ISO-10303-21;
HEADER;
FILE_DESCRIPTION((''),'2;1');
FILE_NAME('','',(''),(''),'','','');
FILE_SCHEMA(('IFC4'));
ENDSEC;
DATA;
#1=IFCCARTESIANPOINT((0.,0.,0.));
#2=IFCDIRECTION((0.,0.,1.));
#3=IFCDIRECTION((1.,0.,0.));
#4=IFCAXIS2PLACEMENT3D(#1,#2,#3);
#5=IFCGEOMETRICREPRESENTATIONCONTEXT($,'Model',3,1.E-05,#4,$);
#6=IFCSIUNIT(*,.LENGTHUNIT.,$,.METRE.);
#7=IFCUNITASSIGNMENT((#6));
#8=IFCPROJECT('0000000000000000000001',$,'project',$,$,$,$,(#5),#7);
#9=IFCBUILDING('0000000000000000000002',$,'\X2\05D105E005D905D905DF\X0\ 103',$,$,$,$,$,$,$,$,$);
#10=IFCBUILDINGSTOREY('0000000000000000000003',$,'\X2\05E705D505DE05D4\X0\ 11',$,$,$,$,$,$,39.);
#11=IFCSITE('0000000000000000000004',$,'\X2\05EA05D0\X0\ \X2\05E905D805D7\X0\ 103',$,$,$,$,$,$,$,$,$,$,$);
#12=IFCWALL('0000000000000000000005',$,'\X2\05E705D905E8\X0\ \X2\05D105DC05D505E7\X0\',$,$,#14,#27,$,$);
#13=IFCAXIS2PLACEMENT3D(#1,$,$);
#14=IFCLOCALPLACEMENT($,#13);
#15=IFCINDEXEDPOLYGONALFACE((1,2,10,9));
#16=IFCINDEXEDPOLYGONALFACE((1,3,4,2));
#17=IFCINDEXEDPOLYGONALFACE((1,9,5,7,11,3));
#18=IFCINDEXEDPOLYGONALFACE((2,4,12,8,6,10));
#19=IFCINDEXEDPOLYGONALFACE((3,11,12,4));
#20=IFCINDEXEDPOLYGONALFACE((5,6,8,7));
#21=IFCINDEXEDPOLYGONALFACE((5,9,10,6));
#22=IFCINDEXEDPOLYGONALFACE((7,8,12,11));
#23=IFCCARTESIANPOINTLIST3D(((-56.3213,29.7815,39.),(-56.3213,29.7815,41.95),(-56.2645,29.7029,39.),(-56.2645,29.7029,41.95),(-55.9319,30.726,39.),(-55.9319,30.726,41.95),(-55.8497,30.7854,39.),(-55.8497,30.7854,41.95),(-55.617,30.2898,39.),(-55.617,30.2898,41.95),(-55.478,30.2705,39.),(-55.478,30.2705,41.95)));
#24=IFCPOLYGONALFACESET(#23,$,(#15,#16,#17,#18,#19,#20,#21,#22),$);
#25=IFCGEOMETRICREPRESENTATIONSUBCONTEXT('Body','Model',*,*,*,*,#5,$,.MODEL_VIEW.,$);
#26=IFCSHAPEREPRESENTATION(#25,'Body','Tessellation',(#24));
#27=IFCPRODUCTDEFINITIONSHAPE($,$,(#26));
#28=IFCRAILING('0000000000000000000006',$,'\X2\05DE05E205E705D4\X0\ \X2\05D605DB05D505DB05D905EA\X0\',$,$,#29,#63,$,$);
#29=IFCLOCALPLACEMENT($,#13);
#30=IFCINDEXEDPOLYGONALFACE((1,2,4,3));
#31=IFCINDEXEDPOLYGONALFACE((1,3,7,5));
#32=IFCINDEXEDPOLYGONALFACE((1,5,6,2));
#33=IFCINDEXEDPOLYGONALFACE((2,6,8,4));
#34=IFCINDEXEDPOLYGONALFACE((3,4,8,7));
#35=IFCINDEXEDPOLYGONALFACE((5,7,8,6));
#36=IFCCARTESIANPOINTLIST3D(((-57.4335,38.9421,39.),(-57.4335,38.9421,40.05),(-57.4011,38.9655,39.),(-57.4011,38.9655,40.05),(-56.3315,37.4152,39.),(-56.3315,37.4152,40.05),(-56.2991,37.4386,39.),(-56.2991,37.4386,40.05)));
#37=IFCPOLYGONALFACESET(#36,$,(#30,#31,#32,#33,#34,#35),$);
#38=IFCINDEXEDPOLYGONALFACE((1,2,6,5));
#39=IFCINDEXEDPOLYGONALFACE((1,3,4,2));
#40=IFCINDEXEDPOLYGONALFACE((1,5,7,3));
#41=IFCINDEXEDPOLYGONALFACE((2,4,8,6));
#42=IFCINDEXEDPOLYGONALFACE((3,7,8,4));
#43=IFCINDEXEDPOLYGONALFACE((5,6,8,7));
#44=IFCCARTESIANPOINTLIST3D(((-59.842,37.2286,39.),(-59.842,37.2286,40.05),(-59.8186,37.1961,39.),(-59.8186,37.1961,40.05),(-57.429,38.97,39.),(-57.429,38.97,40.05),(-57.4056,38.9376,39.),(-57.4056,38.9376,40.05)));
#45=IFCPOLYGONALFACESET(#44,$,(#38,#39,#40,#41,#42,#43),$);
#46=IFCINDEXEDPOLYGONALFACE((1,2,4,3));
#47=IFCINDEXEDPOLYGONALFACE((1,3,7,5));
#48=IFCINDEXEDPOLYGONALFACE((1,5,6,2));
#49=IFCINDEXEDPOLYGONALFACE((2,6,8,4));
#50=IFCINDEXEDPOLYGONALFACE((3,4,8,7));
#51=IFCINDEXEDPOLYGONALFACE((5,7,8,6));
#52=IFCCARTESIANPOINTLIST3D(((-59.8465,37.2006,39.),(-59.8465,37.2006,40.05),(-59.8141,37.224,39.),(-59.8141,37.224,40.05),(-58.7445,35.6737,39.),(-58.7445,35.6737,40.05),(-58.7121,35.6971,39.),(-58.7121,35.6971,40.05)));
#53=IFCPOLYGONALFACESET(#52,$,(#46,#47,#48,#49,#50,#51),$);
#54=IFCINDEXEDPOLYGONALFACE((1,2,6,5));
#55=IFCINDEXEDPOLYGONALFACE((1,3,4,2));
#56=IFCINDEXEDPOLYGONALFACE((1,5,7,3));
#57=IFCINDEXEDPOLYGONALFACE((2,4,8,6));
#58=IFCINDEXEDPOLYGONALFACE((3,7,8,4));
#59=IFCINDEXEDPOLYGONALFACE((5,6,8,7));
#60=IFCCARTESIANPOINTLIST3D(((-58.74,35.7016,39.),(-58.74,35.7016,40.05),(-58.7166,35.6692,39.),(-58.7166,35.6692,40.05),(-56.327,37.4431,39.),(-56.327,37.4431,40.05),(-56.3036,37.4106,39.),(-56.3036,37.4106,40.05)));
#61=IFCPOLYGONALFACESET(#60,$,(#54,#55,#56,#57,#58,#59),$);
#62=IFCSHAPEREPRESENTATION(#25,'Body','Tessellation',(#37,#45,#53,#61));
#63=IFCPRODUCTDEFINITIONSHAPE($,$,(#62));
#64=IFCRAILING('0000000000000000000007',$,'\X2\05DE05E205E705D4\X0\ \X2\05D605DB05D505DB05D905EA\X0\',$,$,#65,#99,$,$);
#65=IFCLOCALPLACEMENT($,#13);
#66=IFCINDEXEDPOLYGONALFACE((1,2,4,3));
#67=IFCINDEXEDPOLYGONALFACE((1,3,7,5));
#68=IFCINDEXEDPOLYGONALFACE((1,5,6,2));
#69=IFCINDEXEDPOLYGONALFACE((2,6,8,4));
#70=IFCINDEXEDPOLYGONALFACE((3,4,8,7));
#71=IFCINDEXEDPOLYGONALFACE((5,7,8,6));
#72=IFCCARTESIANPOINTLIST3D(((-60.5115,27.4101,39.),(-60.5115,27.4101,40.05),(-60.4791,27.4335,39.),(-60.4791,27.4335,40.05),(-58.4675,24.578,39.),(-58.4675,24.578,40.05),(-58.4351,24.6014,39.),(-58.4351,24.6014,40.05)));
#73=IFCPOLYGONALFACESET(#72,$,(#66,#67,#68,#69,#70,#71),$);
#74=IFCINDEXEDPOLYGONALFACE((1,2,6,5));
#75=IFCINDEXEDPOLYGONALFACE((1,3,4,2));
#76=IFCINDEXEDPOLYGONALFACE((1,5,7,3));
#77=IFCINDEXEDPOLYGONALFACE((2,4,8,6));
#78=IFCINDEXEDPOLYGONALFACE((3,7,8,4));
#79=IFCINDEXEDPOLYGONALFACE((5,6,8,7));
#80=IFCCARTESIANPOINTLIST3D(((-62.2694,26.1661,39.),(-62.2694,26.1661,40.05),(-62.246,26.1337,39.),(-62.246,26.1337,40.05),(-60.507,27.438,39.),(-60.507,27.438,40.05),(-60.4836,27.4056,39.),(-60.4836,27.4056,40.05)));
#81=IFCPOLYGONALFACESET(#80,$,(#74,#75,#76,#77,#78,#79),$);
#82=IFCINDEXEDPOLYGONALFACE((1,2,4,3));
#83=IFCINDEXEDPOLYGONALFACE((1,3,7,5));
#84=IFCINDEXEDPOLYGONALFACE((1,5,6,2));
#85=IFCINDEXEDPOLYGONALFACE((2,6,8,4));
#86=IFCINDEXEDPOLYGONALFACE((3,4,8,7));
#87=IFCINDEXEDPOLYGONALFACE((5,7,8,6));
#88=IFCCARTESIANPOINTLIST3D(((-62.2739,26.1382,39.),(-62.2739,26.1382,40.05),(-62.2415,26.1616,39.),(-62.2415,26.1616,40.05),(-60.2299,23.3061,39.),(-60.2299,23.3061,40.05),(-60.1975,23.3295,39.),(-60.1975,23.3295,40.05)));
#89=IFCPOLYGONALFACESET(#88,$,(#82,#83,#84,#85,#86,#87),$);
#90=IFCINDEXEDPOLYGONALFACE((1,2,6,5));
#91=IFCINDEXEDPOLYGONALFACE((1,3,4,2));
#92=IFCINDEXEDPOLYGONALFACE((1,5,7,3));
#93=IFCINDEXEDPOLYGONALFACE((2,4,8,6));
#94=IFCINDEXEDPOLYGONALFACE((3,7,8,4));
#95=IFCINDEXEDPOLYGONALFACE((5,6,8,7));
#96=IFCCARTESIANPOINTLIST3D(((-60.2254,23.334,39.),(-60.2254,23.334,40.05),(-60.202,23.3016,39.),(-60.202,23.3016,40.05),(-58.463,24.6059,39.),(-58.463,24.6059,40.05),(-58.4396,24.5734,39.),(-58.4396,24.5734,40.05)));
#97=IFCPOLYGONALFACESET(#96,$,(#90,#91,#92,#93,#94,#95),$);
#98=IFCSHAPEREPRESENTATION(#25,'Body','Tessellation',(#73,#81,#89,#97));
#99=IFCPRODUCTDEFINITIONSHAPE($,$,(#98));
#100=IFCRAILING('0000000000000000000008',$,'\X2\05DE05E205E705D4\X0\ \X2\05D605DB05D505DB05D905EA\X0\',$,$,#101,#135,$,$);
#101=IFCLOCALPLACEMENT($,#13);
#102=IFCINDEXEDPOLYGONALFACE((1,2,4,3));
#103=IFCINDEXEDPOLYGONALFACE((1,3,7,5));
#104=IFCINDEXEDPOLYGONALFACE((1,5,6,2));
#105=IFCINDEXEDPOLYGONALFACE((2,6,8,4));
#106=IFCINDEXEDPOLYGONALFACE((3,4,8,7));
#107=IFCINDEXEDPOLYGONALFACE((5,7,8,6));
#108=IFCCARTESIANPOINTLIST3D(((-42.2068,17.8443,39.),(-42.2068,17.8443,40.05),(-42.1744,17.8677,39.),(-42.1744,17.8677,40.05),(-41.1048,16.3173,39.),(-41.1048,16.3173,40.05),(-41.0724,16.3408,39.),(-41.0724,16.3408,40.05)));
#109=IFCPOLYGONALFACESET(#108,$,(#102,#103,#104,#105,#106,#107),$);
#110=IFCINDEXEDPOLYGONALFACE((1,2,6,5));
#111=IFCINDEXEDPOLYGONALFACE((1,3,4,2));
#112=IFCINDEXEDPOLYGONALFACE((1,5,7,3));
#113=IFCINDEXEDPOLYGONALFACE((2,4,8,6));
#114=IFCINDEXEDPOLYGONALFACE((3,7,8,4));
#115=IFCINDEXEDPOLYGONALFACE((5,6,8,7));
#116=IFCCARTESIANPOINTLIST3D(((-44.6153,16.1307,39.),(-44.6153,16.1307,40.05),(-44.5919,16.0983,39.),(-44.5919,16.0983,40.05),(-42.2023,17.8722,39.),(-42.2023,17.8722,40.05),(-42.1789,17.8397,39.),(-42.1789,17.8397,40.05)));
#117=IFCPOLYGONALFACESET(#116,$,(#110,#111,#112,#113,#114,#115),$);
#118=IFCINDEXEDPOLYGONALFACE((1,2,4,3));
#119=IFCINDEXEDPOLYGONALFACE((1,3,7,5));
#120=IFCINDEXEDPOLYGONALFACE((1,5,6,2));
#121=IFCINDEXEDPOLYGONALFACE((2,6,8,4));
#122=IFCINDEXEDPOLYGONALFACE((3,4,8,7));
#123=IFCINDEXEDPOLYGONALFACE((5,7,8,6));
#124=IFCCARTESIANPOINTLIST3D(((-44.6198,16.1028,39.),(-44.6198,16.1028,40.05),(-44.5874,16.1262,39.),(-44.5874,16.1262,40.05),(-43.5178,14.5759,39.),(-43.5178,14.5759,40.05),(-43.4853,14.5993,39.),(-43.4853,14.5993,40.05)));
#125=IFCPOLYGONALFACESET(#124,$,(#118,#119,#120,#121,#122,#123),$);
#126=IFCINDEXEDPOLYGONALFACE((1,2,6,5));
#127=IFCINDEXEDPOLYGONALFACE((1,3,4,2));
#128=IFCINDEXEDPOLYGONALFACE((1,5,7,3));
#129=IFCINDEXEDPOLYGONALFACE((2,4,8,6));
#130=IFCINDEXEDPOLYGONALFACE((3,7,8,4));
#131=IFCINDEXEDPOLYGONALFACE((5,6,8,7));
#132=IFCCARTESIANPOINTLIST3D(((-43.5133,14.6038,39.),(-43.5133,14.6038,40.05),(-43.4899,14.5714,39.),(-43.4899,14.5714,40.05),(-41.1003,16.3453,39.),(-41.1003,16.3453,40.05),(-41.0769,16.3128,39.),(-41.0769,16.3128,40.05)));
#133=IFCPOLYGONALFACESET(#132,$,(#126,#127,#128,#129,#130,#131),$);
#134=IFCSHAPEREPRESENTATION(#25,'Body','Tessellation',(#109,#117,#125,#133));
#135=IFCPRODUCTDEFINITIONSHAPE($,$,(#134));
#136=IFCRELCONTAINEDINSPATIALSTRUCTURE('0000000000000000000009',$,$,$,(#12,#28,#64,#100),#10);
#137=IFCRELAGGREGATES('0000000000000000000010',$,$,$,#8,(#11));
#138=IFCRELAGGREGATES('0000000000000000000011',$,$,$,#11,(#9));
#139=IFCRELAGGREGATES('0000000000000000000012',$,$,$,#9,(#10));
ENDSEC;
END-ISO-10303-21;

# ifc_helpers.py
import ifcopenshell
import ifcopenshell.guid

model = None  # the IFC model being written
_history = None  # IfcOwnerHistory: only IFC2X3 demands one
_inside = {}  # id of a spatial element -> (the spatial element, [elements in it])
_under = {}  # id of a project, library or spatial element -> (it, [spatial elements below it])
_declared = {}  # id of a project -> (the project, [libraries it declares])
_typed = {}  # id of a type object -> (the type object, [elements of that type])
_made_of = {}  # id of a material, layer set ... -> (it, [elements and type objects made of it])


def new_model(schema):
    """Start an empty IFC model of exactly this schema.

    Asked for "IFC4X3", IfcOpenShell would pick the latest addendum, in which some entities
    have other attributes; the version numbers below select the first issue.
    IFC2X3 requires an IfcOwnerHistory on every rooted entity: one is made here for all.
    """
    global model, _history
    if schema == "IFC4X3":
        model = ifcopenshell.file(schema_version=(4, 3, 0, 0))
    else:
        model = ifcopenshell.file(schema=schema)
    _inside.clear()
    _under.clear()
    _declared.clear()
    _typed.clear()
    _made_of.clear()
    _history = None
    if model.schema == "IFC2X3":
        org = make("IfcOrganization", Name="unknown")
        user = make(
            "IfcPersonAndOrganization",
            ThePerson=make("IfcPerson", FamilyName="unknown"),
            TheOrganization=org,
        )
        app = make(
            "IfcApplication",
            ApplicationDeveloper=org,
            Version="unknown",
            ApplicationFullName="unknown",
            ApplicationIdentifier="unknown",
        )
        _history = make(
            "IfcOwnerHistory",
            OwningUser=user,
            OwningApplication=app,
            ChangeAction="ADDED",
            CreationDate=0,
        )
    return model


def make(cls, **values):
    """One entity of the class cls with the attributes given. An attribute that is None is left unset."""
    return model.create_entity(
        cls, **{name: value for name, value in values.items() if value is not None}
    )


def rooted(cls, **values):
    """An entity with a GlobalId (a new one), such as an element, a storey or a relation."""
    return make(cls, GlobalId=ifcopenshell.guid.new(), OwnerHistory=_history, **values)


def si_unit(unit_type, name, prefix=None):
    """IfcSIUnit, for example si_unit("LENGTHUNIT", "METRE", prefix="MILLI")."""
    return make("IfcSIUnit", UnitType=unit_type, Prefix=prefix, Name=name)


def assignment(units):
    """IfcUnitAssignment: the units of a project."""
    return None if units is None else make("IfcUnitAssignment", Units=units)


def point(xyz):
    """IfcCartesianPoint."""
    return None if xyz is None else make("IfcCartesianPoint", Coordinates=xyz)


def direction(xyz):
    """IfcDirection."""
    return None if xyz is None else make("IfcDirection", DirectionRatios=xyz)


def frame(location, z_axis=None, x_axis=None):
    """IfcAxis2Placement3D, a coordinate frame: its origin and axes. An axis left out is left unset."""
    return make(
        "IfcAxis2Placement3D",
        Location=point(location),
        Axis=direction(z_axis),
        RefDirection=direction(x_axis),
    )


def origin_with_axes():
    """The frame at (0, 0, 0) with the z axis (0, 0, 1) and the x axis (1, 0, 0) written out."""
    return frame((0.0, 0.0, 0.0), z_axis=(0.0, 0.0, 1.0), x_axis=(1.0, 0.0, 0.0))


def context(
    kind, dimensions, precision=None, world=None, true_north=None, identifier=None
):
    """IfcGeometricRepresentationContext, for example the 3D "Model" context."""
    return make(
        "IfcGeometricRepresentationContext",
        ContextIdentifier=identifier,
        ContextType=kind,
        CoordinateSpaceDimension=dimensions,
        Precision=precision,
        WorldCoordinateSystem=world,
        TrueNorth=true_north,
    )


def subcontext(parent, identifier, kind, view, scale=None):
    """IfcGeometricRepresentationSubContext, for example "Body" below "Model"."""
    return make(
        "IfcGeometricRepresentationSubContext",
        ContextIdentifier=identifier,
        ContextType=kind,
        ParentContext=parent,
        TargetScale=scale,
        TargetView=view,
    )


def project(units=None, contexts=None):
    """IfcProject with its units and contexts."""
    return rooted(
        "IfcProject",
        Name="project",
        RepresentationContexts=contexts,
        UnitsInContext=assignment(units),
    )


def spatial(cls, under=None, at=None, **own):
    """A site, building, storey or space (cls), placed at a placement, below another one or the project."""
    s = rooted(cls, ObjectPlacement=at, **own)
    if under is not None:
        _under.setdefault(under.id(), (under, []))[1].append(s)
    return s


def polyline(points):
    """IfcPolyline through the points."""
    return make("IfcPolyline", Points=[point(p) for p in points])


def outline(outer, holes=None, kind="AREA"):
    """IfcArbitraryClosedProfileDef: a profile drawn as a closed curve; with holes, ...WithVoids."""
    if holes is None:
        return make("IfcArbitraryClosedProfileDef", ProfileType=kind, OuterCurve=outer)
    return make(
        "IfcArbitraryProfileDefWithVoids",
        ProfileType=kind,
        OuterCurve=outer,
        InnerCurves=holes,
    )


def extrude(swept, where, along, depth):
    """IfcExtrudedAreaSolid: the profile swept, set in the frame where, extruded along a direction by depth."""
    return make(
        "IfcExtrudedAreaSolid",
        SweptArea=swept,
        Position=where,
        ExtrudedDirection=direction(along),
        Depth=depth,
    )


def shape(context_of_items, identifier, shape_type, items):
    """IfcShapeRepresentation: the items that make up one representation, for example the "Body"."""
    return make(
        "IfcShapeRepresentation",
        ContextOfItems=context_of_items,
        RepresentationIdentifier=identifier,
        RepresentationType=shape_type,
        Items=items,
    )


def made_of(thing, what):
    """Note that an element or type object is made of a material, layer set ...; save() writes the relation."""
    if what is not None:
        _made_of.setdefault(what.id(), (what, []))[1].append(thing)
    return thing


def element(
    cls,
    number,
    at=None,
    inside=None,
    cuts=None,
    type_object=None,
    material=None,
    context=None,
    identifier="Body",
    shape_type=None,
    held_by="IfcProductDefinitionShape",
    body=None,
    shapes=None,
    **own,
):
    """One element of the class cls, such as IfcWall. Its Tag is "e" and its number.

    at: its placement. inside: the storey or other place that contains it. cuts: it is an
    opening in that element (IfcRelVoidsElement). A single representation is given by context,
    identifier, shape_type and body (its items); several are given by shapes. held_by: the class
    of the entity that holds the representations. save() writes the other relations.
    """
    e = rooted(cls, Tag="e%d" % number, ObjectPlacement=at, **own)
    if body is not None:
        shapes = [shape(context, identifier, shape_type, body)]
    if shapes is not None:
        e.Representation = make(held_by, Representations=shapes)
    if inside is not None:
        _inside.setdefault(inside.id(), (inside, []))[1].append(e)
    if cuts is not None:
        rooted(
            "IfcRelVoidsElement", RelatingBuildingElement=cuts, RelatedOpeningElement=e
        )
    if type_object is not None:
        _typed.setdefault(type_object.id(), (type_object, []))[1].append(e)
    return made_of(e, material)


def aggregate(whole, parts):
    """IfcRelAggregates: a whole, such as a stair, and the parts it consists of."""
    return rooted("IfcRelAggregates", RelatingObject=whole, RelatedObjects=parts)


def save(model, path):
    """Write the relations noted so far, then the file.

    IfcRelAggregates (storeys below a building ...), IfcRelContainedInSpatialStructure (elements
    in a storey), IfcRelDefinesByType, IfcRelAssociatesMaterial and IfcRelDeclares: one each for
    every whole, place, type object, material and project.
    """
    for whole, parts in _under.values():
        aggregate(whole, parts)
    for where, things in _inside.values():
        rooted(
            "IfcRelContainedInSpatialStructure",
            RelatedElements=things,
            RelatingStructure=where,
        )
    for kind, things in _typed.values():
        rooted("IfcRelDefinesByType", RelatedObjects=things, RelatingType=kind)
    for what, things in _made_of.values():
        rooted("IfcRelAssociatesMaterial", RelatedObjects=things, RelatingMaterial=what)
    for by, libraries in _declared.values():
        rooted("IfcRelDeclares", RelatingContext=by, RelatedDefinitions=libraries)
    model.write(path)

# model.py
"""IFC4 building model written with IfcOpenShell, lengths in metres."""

from ifc_helpers import new_model, si_unit, frame, origin_with_axes, context, subcontext, project, spatial, polyline, outline, extrude, element, save


model = new_model("IFC4")

# Units and contexts
model_context = context("Model", 3, precision=1e-05, world=origin_with_axes())
body_context = subcontext(model_context, "Body", "Model", "MODEL_VIEW")
ifc_project = project(units=[si_unit("LENGTHUNIT", "METRE")], contexts=[model_context])

# Site, building, storey
site = spatial("IfcSite", under=ifc_project, Name="תא שטח 103")
building = spatial("IfcBuilding", under=site, Name="בניין 103")
storey = spatial("IfcBuildingStorey", under=building, Name="קומה 11", Elevation=39.0)

# Wall
element("IfcWall", 1, inside=storey, Name="קיר בלוק", context=body_context, shape_type="SweptSolid", body=[
    extrude(outline(polyline([(-55.9319, 30.726), (-55.8497, 30.7854), (-55.478, 30.2705), (-56.2645, 29.7029), (-56.3213, 29.7815), (-55.617, 30.2898), (-55.9319, 30.726)])), frame((0.0, 0.0, 39.0)), (0.0, 0.0, 1.0), 2.95),
])

# Railings
element("IfcRailing", 2, inside=storey, Name="מעקה זכוכית", context=body_context, shape_type="SweptSolid", body=[
    extrude(outline(polyline([(-56.2991, 37.4386), (-57.4011, 38.9655), (-57.4335, 38.9421), (-56.3315, 37.4152), (-56.2991, 37.4386)])), frame((0.0, 0.0, 39.0)), (0.0, 0.0, 1.0), 1.05),
    extrude(outline(polyline([(-57.429, 38.97), (-59.842, 37.2286), (-59.8186, 37.1961), (-57.4056, 38.9376), (-57.429, 38.97)])), frame((0.0, 0.0, 39.0)), (0.0, 0.0, 1.0), 1.05),
    extrude(outline(polyline([(-59.8465, 37.2006), (-58.7445, 35.6737), (-58.7121, 35.6971), (-59.8141, 37.224), (-59.8465, 37.2006)])), frame((0.0, 0.0, 39.0)), (0.0, 0.0, 1.0), 1.05),
    extrude(outline(polyline([(-58.7166, 35.6692), (-56.3036, 37.4106), (-56.327, 37.4431), (-58.74, 35.7016), (-58.7166, 35.6692)])), frame((0.0, 0.0, 39.0)), (0.0, 0.0, 1.0), 1.05),
])
element("IfcRailing", 3, inside=storey, Name="מעקה זכוכית", context=body_context, shape_type="SweptSolid", body=[
    extrude(outline(polyline([(-58.4351, 24.6014), (-60.4791, 27.4335), (-60.5115, 27.4101), (-58.4675, 24.578), (-58.4351, 24.6014)])), frame((0.0, 0.0, 39.0)), (0.0, 0.0, 1.0), 1.05),
    extrude(outline(polyline([(-60.507, 27.438), (-62.2694, 26.1661), (-62.246, 26.1337), (-60.4836, 27.4056), (-60.507, 27.438)])), frame((0.0, 0.0, 39.0)), (0.0, 0.0, 1.0), 1.05),
    extrude(outline(polyline([(-62.2739, 26.1382), (-60.2299, 23.3061), (-60.1975, 23.3295), (-62.2415, 26.1616), (-62.2739, 26.1382)])), frame((0.0, 0.0, 39.0)), (0.0, 0.0, 1.0), 1.05),
    extrude(outline(polyline([(-60.202, 23.3016), (-58.4396, 24.5734), (-58.463, 24.6059), (-60.2254, 23.334), (-60.202, 23.3016)])), frame((0.0, 0.0, 39.0)), (0.0, 0.0, 1.0), 1.05),
])
element("IfcRailing", 4, inside=storey, Name="מעקה זכוכית", context=body_context, shape_type="SweptSolid", body=[
    extrude(outline(polyline([(-41.0724, 16.3408), (-42.1744, 17.8677), (-42.2068, 17.8443), (-41.1048, 16.3173), (-41.0724, 16.3408)])), frame((0.0, 0.0, 39.0)), (0.0, 0.0, 1.0), 1.05),
    extrude(outline(polyline([(-42.2023, 17.8722), (-44.6153, 16.1307), (-44.5919, 16.0983), (-42.1789, 17.8397), (-42.2023, 17.8722)])), frame((0.0, 0.0, 39.0)), (0.0, 0.0, 1.0), 1.05),
    extrude(outline(polyline([(-44.6198, 16.1028), (-43.5178, 14.5759), (-43.4853, 14.5993), (-44.5874, 16.1262), (-44.6198, 16.1028)])), frame((0.0, 0.0, 39.0)), (0.0, 0.0, 1.0), 1.05),
    extrude(outline(polyline([(-43.4899, 14.5714), (-41.0769, 16.3128), (-41.1003, 16.3453), (-43.5133, 14.6038), (-43.4899, 14.5714)])), frame((0.0, 0.0, 39.0)), (0.0, 0.0, 1.0), 1.05),
])

save(model, "model.ifc")
